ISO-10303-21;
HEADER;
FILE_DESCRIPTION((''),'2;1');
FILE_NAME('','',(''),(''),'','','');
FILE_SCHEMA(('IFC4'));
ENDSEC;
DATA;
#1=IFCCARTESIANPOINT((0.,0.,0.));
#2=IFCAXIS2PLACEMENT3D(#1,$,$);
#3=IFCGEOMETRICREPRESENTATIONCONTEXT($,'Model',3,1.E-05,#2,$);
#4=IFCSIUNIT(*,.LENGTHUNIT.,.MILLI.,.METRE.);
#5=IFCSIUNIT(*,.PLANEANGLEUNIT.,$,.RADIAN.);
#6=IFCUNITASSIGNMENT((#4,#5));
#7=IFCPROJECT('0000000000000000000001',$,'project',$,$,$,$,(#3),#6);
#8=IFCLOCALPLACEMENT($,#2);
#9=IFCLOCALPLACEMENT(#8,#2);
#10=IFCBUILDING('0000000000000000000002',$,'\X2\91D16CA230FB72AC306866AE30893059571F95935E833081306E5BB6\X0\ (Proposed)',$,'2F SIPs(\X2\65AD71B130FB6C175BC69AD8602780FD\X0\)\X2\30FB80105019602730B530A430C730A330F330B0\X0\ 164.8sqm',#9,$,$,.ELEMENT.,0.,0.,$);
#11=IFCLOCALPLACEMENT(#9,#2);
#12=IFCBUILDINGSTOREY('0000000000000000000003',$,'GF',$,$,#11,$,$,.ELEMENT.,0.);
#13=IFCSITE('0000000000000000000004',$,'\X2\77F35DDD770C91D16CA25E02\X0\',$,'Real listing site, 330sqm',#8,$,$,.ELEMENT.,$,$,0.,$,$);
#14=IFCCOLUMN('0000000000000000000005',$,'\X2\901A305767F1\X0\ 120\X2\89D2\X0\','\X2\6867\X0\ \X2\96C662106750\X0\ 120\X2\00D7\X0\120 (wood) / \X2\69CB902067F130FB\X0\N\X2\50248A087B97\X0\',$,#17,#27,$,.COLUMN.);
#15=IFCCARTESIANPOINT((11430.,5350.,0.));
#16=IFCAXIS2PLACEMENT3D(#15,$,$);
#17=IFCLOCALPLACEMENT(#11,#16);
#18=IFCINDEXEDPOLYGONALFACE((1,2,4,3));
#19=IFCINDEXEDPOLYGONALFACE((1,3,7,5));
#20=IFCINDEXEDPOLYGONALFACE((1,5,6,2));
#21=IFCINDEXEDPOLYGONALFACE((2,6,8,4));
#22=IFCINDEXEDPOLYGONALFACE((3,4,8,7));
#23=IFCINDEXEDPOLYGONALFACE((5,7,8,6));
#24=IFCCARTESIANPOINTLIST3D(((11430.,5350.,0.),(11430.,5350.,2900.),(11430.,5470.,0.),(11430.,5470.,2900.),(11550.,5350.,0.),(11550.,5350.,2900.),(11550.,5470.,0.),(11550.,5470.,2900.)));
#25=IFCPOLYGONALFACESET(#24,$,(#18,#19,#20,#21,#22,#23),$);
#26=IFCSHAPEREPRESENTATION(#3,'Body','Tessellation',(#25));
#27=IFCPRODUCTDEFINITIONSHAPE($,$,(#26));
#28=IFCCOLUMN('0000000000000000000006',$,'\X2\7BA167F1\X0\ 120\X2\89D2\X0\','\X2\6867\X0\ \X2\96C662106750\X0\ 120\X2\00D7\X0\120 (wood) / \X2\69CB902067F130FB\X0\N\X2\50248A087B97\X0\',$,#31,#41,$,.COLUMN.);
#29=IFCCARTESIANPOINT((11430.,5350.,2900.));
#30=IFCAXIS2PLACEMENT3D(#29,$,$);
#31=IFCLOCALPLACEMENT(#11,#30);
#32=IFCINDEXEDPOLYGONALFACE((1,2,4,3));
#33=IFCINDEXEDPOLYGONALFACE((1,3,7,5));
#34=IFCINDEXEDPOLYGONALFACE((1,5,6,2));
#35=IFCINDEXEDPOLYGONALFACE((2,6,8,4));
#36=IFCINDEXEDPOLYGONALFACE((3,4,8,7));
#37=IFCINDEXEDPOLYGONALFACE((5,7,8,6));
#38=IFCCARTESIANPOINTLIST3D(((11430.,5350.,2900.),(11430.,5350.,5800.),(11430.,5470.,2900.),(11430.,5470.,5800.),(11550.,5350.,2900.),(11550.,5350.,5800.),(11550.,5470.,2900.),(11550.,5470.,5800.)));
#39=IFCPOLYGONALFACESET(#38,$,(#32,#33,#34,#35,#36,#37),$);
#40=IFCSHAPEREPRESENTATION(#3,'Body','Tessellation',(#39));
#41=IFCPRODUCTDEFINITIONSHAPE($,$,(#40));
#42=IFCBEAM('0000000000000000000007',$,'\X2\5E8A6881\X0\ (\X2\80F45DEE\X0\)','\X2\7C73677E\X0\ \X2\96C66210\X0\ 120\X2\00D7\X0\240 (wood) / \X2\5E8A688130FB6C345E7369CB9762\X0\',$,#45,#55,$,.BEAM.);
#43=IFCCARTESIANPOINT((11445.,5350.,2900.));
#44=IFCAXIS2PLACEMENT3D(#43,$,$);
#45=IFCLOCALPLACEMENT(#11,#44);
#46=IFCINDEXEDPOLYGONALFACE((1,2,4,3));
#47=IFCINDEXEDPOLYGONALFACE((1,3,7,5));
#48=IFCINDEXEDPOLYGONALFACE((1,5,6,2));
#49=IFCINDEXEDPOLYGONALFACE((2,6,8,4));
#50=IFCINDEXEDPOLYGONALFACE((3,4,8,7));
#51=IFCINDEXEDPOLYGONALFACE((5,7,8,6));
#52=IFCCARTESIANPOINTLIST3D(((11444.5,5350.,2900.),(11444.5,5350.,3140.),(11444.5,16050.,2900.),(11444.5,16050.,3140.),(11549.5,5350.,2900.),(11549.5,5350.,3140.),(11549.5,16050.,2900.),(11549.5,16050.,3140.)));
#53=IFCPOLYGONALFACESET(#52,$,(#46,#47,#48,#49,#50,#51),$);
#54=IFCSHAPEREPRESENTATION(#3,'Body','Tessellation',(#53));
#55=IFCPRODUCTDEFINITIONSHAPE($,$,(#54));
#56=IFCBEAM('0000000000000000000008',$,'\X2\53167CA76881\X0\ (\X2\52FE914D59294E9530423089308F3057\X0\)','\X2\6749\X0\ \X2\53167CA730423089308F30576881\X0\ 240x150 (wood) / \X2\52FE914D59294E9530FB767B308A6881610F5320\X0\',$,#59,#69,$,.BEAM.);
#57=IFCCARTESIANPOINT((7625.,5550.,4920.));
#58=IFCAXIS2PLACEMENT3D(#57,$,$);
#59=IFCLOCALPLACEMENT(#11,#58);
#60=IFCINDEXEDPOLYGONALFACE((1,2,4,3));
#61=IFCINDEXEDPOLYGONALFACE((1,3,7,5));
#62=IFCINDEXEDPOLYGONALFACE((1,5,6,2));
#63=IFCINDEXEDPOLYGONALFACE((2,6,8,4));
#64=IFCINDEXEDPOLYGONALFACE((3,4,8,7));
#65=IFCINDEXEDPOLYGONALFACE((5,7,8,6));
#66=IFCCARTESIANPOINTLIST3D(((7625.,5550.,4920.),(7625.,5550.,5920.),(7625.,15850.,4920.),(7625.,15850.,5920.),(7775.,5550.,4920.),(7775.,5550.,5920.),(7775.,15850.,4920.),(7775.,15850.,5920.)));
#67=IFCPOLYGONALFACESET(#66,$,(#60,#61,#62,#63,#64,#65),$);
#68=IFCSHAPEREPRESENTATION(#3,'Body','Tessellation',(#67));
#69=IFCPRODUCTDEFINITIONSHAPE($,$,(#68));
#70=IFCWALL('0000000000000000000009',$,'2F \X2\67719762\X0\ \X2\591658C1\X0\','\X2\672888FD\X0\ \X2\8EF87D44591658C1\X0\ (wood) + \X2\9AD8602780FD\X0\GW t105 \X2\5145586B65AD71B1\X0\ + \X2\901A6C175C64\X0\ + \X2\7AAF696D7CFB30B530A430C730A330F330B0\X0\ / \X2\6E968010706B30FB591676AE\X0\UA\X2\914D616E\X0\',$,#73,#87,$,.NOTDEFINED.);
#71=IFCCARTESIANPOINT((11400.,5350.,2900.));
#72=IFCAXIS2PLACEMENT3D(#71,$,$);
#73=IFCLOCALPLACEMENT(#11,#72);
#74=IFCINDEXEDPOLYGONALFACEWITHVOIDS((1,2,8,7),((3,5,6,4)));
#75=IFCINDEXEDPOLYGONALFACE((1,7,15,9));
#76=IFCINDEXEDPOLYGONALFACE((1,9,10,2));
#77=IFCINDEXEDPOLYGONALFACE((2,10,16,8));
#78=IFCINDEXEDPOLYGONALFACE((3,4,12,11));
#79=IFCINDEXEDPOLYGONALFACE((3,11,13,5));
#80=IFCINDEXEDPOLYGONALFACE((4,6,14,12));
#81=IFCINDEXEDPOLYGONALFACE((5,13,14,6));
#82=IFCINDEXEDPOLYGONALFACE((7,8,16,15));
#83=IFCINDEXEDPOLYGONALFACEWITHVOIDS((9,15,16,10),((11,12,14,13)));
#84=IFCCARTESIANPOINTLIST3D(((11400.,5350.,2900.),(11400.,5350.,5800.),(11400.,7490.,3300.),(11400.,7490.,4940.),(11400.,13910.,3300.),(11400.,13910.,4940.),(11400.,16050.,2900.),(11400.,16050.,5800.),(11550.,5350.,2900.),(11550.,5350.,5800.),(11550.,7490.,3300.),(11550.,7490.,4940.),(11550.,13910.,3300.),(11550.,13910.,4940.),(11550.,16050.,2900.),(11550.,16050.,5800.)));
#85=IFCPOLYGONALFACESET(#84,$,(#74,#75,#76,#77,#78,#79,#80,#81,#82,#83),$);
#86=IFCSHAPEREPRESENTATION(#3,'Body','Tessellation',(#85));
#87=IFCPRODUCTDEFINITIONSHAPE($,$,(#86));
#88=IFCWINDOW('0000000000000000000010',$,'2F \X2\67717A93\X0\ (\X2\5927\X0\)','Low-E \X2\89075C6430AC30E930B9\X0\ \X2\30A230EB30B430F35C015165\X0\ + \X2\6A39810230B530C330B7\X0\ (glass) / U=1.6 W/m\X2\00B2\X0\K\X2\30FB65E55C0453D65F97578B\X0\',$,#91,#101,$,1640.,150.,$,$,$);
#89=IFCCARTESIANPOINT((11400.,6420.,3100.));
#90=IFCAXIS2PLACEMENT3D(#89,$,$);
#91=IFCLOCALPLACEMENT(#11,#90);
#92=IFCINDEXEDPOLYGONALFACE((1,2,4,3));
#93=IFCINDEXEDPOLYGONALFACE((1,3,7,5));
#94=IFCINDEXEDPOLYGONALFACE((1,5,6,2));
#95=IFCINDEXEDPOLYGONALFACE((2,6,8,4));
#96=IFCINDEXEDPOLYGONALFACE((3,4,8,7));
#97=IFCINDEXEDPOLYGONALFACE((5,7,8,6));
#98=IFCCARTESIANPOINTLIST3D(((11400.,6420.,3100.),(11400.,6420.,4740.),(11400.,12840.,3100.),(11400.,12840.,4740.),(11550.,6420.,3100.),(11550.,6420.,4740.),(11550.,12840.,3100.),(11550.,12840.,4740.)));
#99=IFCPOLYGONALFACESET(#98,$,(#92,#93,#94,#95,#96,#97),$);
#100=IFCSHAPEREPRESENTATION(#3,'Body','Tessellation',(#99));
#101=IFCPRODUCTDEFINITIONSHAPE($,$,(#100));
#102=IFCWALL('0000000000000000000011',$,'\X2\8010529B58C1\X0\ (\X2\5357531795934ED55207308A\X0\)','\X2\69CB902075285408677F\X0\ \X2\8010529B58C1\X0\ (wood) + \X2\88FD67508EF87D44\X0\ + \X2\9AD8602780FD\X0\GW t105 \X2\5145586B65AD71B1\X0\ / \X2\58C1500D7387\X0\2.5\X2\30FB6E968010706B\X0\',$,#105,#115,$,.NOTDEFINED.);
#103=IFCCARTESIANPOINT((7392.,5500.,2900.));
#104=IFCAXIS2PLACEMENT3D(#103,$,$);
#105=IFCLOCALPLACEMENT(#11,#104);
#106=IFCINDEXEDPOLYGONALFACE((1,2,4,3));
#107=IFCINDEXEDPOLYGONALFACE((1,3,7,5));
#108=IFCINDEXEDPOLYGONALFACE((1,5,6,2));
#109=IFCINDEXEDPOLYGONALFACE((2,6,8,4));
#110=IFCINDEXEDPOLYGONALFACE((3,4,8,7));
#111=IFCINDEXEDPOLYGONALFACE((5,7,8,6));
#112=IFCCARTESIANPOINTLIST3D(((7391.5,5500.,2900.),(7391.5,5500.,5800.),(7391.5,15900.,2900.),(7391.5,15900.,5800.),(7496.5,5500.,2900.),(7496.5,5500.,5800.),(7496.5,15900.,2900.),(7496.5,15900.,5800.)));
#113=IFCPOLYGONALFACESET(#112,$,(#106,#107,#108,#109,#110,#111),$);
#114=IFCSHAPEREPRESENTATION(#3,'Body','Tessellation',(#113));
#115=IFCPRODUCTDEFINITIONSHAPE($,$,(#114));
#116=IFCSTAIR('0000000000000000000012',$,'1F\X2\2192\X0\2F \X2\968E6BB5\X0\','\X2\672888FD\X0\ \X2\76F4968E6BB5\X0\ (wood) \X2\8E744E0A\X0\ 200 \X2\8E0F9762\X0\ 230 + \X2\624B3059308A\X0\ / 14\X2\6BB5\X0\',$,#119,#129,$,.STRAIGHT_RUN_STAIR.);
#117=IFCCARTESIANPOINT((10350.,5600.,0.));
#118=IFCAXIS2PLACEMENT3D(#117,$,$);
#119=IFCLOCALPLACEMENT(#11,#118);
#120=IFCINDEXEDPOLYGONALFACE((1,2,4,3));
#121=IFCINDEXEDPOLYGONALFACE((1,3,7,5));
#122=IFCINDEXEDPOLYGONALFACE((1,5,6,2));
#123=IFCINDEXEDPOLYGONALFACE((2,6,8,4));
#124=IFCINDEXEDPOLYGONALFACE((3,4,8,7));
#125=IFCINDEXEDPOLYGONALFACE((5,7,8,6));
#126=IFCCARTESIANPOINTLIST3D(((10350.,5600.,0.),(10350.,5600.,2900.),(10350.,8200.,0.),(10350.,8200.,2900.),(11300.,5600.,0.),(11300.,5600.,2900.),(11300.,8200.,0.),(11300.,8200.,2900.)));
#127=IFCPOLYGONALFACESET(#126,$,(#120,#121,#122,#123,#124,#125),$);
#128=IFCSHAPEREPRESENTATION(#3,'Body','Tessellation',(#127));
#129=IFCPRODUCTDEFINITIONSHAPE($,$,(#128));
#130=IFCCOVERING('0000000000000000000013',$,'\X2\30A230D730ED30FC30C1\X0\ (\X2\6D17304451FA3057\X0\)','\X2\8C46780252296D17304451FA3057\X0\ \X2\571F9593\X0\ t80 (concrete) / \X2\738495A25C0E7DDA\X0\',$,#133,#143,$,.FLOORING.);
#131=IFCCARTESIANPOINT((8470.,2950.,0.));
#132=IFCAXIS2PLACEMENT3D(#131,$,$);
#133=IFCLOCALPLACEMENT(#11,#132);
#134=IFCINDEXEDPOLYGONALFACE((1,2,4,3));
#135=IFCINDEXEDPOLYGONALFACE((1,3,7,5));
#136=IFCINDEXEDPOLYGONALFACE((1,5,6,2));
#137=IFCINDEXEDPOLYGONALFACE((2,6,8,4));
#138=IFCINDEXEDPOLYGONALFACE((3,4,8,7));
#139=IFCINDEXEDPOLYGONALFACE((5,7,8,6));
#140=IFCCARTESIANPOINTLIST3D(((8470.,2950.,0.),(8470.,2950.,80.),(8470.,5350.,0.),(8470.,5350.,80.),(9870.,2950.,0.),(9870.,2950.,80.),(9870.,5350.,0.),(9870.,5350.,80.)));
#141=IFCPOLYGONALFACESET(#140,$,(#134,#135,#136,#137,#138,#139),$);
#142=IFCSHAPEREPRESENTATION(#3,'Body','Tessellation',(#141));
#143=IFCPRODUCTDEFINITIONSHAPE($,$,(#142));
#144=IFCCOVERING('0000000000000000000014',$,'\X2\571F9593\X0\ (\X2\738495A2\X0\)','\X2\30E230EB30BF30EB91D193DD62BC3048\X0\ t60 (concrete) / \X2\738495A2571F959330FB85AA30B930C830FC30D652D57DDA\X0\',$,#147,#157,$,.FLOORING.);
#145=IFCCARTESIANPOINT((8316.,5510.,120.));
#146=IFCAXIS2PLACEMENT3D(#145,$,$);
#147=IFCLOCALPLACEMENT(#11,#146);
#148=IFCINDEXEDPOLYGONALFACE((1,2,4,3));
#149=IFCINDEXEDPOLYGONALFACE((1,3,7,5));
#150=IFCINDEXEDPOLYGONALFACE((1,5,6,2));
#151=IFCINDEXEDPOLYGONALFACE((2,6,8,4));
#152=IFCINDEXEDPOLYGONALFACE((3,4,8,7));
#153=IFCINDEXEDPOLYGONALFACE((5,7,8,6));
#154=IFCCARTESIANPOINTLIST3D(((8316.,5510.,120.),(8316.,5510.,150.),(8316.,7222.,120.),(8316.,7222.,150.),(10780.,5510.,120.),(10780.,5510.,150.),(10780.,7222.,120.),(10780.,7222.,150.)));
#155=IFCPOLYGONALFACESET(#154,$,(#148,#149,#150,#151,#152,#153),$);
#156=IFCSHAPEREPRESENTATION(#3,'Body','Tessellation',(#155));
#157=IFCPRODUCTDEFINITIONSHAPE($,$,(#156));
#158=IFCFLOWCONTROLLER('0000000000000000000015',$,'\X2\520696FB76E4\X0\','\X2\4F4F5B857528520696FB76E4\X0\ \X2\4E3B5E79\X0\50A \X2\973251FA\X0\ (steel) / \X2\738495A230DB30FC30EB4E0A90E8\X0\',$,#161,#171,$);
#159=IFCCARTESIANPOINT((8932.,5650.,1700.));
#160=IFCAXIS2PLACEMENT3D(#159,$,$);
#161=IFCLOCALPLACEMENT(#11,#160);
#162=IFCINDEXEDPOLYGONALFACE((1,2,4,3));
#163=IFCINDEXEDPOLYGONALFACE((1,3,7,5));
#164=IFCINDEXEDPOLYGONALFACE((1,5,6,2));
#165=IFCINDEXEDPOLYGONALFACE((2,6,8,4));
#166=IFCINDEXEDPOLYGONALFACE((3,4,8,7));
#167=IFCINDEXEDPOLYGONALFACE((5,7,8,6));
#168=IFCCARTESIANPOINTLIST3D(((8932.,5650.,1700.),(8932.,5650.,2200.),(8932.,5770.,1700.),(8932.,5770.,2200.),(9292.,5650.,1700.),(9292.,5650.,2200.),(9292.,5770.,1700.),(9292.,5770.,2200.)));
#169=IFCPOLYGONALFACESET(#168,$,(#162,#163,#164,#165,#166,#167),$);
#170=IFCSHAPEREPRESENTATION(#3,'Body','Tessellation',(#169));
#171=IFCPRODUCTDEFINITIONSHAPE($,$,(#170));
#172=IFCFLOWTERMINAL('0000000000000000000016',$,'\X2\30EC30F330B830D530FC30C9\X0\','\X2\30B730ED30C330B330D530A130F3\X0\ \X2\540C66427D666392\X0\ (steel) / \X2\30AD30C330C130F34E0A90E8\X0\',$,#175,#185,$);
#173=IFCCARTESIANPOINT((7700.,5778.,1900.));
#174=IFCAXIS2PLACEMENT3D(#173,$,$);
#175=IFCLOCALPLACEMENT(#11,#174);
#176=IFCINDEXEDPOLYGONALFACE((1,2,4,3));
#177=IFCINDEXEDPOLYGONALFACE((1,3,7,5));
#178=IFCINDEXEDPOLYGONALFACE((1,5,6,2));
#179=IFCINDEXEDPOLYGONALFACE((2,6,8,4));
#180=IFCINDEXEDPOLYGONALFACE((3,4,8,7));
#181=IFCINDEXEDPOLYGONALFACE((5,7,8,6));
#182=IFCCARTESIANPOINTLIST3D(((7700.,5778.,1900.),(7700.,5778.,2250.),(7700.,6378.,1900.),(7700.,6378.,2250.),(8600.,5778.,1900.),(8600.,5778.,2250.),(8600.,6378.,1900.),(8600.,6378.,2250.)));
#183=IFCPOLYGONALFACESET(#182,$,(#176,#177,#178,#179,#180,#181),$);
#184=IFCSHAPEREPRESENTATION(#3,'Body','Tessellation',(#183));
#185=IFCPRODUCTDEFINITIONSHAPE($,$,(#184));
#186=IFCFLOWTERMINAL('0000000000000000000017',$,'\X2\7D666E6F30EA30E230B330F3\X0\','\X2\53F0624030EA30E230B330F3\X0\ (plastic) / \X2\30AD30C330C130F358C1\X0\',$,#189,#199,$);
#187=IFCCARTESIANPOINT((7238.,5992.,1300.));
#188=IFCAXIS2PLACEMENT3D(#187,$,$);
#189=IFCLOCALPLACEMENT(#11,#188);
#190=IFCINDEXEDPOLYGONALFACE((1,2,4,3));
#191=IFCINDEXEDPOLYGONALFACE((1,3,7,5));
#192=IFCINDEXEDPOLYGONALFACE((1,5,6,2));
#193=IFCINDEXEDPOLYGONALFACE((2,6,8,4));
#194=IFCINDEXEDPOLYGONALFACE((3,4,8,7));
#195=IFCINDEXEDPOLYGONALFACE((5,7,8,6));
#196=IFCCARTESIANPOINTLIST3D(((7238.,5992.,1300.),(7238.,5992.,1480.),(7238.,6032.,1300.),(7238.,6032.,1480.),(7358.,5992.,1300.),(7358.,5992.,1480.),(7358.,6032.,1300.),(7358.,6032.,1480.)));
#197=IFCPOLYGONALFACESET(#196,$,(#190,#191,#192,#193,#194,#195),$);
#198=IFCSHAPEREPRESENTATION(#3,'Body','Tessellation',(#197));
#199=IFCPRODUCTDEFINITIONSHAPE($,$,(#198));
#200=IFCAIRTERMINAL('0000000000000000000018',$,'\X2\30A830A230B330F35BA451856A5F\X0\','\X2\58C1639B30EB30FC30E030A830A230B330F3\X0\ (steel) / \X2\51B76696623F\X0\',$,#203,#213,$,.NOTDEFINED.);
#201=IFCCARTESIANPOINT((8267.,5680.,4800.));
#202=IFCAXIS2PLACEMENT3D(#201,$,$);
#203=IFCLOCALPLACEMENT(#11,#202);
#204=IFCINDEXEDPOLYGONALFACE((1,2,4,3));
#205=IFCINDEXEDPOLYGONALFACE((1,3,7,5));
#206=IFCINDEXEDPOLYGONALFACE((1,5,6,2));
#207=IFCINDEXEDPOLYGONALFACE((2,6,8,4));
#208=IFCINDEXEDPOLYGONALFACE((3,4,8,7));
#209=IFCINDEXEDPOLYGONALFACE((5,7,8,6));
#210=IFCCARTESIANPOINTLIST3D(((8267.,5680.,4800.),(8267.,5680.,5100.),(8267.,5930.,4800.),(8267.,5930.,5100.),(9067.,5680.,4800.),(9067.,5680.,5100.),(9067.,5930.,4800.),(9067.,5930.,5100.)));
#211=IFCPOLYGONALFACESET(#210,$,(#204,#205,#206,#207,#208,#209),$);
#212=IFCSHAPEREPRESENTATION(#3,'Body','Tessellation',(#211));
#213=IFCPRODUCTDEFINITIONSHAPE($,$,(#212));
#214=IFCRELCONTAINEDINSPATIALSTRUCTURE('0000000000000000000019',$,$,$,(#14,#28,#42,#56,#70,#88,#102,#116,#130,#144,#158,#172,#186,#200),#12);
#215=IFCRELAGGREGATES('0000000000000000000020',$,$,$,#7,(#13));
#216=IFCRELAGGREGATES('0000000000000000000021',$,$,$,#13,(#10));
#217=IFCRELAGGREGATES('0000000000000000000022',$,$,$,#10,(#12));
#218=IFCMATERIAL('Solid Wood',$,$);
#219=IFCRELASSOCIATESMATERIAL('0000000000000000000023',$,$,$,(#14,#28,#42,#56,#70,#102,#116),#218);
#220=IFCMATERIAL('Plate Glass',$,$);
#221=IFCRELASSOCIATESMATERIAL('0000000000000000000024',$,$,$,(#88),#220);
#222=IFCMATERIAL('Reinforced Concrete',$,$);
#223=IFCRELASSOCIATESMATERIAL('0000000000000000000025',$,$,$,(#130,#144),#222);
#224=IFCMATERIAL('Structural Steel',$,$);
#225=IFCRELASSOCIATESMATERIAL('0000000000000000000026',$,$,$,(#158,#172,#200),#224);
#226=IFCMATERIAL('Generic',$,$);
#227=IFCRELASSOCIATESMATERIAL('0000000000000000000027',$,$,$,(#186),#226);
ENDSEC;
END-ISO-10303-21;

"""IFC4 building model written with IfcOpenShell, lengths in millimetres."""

from ifc_helpers import new_model, si_unit, frame, frame_2d, origin, place, context, project, spatial, rectangle, extrude, material, element, fill, save


model = new_model("IFC4")

# Units and contexts
model_context = context("Model", 3, precision=1e-05, world=origin())
ifc_project = project(units=[si_unit("LENGTHUNIT", "METRE", prefix="MILLI"), si_unit("PLANEANGLEUNIT", "RADIAN")], contexts=[model_context])

# Site, building, storey
site_placement = place(None, origin())
site = spatial("IfcSite", under=ifc_project, at=site_placement, Name="石川県金沢市", ObjectType="Real listing site, 330sqm", CompositionType="ELEMENT", RefElevation=0.0)
building_placement = place(site_placement, origin())
building = spatial("IfcBuilding", under=site, at=building_placement, Name="金沢・犬と暮らす土間広めの家 (Proposed)", ObjectType="2F SIPs(断熱・気密高性能)・耐候性サイディング 164.8sqm", CompositionType="ELEMENT", ElevationOfRefHeight=0.0, ElevationOfTerrain=0.0)
storey_placement = place(building_placement, origin())
storey = spatial("IfcBuildingStorey", under=building, at=storey_placement, Name="GF", CompositionType="ELEMENT", Elevation=0.0)

# Columns
ifc_material_1 = material(Name="Solid Wood")
column_1_placement = place(storey_placement, frame((11430.0, 5350.0, 0.0)))
element("IfcColumn", 1, at=column_1_placement, inside=storey, material=ifc_material_1, Name="通し柱 120角", Description="桧 集成材 120×120 (wood) / 構造柱・N値計算", PredefinedType="COLUMN", context=model_context, shape_type="SweptSolid", body=[
    extrude(rectangle(XDim=120.0, YDim=120.0, at=frame_2d((60.0, 60.0))), frame((11430.0, 5350.0, 0.0)), (0.0, 0.0, 1.0), 2900.0),
])
column_2_placement = place(storey_placement, frame((11430.0, 5350.0, 2900.0)))
element("IfcColumn", 2, at=column_2_placement, inside=storey, material=ifc_material_1, Name="管柱 120角", Description="桧 集成材 120×120 (wood) / 構造柱・N値計算", PredefinedType="COLUMN", context=model_context, shape_type="SweptSolid", body=[
    extrude(rectangle(XDim=120.0, YDim=120.0, at=frame_2d((60.0, 60.0))), frame((11430.0, 5350.0, 2900.0)), (0.0, 0.0, 1.0), 2900.0),
])

# Beams
beam_1_placement = place(storey_placement, frame((11445.0, 5350.0, 2900.0)))
element("IfcBeam", 3, at=beam_1_placement, inside=storey, material=ifc_material_1, Name="床梁 (胴差)", Description="米松 集成 120×240 (wood) / 床梁・水平構面", PredefinedType="BEAM", context=model_context, shape_type="SweptSolid", body=[
    extrude(rectangle(XDim=105.0, YDim=10700.0, at=frame_2d((52.0, 5350.0))), frame((11445.0, 5350.0, 2900.0)), (0.0, 0.0, 1.0), 240.0),
])
beam_2_placement = place(storey_placement, frame((7625.0, 5550.0, 4920.0)))
element("IfcBeam", 4, at=beam_2_placement, inside=storey, material=ifc_material_1, Name="化粧梁 (勾配天井あらわし)", Description="杉 化粧あらわし梁 240x150 (wood) / 勾配天井・登り梁意匠", PredefinedType="BEAM", context=model_context, shape_type="SweptSolid", body=[
    extrude(rectangle(XDim=150.0, YDim=10300.0, at=frame_2d((75.0, 5150.0))), frame((7625.0, 5550.0, 4920.0)), (0.0, 0.0, 1.0), 1000.0),
])

# Shared definitions
ifc_material_2 = material(Name="Plate Glass")

# Wall, opening, window
wall_1_placement = place(storey_placement, frame((11400.0, 5350.0, 2900.0)))
wall_1 = element("IfcWall", 5, at=wall_1_placement, inside=storey, material=ifc_material_1, Name="2F 東面 外壁", Description="木製 軸組外壁 (wood) + 高性能GW t105 充填断熱 + 通気層 + 窯業系サイディング / 準耐火・外皮UA配慮", PredefinedType="NOTDEFINED", context=model_context, shape_type="SweptSolid", body=[
    extrude(rectangle(XDim=150.0, YDim=10700.0, at=frame_2d((75.0, 5350.0))), frame((11400.0, 5350.0, 2900.0)), (0.0, 0.0, 1.0), 2900.0),
])
opening_1_placement = place(storey_placement, frame((11400.0, 6420.0, 3100.0)))
opening_1 = element("IfcOpeningElement", 6, at=opening_1_placement, cuts=wall_1, PredefinedType="NOTDEFINED", context=model_context, shape_type="SweptSolid", body=[
    extrude(rectangle(XDim=150.0, YDim=6420.0, at=frame_2d((75.0, 3210.0))), frame((11400.0, 6420.0, 3100.0)), (0.0, 0.0, 1.0), 1640.0),
])
window_1_placement = place(storey_placement, frame((11400.0, 6420.0, 3100.0)))
window_1 = element("IfcWindow", 7, at=window_1_placement, inside=storey, material=ifc_material_2, Name="2F 東窓 (大)", Description="Low-E 複層ガラス アルゴン封入 + 樹脂サッシ (glass) / U=1.6 W/m²K・日射取得型", OverallHeight=1640.0, OverallWidth=150.0, context=model_context, shape_type="SweptSolid", body=[
    extrude(rectangle(XDim=150.0, YDim=6420.0, at=frame_2d((75.0, 3210.0))), frame((11400.0, 6420.0, 3100.0)), (0.0, 0.0, 1.0), 1640.0),
])
fill(opening_1, window_1)

# Wall
wall_2_placement = place(storey_placement, frame((7392.0, 5500.0, 2900.0)))
element("IfcWall", 8, at=wall_2_placement, inside=storey, material=ifc_material_1, Name="耐力壁 (南北間仕切り)", Description="構造用合板 耐力壁 (wood) + 製材軸組 + 高性能GW t105 充填断熱 / 壁倍率2.5・準耐火", PredefinedType="NOTDEFINED", context=model_context, shape_type="SweptSolid", body=[
    extrude(rectangle(XDim=105.0, YDim=10400.0, at=frame_2d((52.0, 5200.0))), frame((7392.0, 5500.0, 2900.0)), (0.0, 0.0, 1.0), 2900.0),
])

# Stair
stair_placement = place(storey_placement, frame((10350.0, 5600.0, 0.0)))
element("IfcStair", 9, at=stair_placement, inside=storey, material=ifc_material_1, Name="1F→2F 階段", Description="木製 直階段 (wood) 蹴上 200 踏面 230 + 手すり / 14段", PredefinedType="STRAIGHT_RUN_STAIR", context=model_context, shape_type="SweptSolid", body=[
    extrude(rectangle(XDim=950.0, YDim=2600.0, at=frame_2d((475.0, 1300.0))), frame((10350.0, 5600.0, 0.0)), (0.0, 0.0, 1.0), 2900.0),
])

# Coverings
ifc_material_3 = material(Name="Reinforced Concrete")
covering_1_placement = place(storey_placement, frame((8470.0, 2950.0, 0.0)))
element("IfcCovering", 10, at=covering_1_placement, inside=storey, material=ifc_material_3, Name="アプローチ (洗い出し)", Description="豆砂利洗い出し 土間 t80 (concrete) / 玄関導線", PredefinedType="FLOORING", context=model_context, shape_type="SweptSolid", body=[
    extrude(rectangle(XDim=1400.0, YDim=2400.0, at=frame_2d((700.0, 1200.0))), frame((8470.0, 2950.0, 0.0)), (0.0, 0.0, 1.0), 80.0),
])
covering_2_placement = place(storey_placement, frame((8316.0, 5510.0, 120.0)))
element("IfcCovering", 11, at=covering_2_placement, inside=storey, material=ifc_material_3, Name="土間 (玄関)", Description="モルタル金鏝押え t60 (concrete) / 玄関土間・薪ストーブ動線", PredefinedType="FLOORING", context=model_context, shape_type="SweptSolid", body=[
    extrude(rectangle(XDim=2464.0, YDim=1712.0, at=frame_2d((1232.0, 856.0))), frame((8316.0, 5510.0, 120.0)), (0.0, 0.0, 1.0), 30.0),
])

# Flow controller
ifc_material_4 = material(Name="Structural Steel")
flow_controller_placement = place(storey_placement, frame((8932.0, 5650.0, 1700.0)))
element("IfcFlowController", 12, at=flow_controller_placement, inside=storey, material=ifc_material_4, Name="分電盤", Description="住宅用分電盤 主幹50A 露出 (steel) / 玄関ホール上部", context=model_context, shape_type="SweptSolid", body=[
    extrude(rectangle(XDim=360.0, YDim=120.0, at=frame_2d((180.0, 60.0))), frame((8932.0, 5650.0, 1700.0)), (0.0, 0.0, 1.0), 500.0),
])

# Flow terminals
flow_terminal_1_placement = place(storey_placement, frame((7700.0, 5778.0, 1900.0)))
element("IfcFlowTerminal", 13, at=flow_terminal_1_placement, inside=storey, material=ifc_material_4, Name="レンジフード", Description="シロッコファン 同時給排 (steel) / キッチン上部", context=model_context, shape_type="SweptSolid", body=[
    extrude(rectangle(XDim=900.0, YDim=600.0, at=frame_2d((450.0, 300.0))), frame((7700.0, 5778.0, 1900.0)), (0.0, 0.0, 1.0), 350.0),
])
ifc_material_5 = material(Name="Generic")
flow_terminal_2_placement = place(storey_placement, frame((7238.0, 5992.0, 1300.0)))
element("IfcFlowTerminal", 14, at=flow_terminal_2_placement, inside=storey, material=ifc_material_5, Name="給湯リモコン", Description="台所リモコン (plastic) / キッチン壁", context=model_context, shape_type="SweptSolid", body=[
    extrude(rectangle(XDim=120.0, YDim=40.0, at=frame_2d((60.0, 20.0))), frame((7238.0, 5992.0, 1300.0)), (0.0, 0.0, 1.0), 180.0),
])

# Air terminal
air_terminal_placement = place(storey_placement, frame((8267.0, 5680.0, 4800.0)))
element("IfcAirTerminal", 15, at=air_terminal_placement, inside=storey, material=ifc_material_4, Name="エアコン室内機", Description="壁掛ルームエアコン (steel) / 冷暖房", PredefinedType="NOTDEFINED", context=model_context, shape_type="SweptSolid", body=[
    extrude(rectangle(XDim=800.0, YDim=250.0, at=frame_2d((400.0, 125.0))), frame((8267.0, 5680.0, 4800.0)), (0.0, 0.0, 1.0), 300.0),
])

save(model, "model.ifc")
